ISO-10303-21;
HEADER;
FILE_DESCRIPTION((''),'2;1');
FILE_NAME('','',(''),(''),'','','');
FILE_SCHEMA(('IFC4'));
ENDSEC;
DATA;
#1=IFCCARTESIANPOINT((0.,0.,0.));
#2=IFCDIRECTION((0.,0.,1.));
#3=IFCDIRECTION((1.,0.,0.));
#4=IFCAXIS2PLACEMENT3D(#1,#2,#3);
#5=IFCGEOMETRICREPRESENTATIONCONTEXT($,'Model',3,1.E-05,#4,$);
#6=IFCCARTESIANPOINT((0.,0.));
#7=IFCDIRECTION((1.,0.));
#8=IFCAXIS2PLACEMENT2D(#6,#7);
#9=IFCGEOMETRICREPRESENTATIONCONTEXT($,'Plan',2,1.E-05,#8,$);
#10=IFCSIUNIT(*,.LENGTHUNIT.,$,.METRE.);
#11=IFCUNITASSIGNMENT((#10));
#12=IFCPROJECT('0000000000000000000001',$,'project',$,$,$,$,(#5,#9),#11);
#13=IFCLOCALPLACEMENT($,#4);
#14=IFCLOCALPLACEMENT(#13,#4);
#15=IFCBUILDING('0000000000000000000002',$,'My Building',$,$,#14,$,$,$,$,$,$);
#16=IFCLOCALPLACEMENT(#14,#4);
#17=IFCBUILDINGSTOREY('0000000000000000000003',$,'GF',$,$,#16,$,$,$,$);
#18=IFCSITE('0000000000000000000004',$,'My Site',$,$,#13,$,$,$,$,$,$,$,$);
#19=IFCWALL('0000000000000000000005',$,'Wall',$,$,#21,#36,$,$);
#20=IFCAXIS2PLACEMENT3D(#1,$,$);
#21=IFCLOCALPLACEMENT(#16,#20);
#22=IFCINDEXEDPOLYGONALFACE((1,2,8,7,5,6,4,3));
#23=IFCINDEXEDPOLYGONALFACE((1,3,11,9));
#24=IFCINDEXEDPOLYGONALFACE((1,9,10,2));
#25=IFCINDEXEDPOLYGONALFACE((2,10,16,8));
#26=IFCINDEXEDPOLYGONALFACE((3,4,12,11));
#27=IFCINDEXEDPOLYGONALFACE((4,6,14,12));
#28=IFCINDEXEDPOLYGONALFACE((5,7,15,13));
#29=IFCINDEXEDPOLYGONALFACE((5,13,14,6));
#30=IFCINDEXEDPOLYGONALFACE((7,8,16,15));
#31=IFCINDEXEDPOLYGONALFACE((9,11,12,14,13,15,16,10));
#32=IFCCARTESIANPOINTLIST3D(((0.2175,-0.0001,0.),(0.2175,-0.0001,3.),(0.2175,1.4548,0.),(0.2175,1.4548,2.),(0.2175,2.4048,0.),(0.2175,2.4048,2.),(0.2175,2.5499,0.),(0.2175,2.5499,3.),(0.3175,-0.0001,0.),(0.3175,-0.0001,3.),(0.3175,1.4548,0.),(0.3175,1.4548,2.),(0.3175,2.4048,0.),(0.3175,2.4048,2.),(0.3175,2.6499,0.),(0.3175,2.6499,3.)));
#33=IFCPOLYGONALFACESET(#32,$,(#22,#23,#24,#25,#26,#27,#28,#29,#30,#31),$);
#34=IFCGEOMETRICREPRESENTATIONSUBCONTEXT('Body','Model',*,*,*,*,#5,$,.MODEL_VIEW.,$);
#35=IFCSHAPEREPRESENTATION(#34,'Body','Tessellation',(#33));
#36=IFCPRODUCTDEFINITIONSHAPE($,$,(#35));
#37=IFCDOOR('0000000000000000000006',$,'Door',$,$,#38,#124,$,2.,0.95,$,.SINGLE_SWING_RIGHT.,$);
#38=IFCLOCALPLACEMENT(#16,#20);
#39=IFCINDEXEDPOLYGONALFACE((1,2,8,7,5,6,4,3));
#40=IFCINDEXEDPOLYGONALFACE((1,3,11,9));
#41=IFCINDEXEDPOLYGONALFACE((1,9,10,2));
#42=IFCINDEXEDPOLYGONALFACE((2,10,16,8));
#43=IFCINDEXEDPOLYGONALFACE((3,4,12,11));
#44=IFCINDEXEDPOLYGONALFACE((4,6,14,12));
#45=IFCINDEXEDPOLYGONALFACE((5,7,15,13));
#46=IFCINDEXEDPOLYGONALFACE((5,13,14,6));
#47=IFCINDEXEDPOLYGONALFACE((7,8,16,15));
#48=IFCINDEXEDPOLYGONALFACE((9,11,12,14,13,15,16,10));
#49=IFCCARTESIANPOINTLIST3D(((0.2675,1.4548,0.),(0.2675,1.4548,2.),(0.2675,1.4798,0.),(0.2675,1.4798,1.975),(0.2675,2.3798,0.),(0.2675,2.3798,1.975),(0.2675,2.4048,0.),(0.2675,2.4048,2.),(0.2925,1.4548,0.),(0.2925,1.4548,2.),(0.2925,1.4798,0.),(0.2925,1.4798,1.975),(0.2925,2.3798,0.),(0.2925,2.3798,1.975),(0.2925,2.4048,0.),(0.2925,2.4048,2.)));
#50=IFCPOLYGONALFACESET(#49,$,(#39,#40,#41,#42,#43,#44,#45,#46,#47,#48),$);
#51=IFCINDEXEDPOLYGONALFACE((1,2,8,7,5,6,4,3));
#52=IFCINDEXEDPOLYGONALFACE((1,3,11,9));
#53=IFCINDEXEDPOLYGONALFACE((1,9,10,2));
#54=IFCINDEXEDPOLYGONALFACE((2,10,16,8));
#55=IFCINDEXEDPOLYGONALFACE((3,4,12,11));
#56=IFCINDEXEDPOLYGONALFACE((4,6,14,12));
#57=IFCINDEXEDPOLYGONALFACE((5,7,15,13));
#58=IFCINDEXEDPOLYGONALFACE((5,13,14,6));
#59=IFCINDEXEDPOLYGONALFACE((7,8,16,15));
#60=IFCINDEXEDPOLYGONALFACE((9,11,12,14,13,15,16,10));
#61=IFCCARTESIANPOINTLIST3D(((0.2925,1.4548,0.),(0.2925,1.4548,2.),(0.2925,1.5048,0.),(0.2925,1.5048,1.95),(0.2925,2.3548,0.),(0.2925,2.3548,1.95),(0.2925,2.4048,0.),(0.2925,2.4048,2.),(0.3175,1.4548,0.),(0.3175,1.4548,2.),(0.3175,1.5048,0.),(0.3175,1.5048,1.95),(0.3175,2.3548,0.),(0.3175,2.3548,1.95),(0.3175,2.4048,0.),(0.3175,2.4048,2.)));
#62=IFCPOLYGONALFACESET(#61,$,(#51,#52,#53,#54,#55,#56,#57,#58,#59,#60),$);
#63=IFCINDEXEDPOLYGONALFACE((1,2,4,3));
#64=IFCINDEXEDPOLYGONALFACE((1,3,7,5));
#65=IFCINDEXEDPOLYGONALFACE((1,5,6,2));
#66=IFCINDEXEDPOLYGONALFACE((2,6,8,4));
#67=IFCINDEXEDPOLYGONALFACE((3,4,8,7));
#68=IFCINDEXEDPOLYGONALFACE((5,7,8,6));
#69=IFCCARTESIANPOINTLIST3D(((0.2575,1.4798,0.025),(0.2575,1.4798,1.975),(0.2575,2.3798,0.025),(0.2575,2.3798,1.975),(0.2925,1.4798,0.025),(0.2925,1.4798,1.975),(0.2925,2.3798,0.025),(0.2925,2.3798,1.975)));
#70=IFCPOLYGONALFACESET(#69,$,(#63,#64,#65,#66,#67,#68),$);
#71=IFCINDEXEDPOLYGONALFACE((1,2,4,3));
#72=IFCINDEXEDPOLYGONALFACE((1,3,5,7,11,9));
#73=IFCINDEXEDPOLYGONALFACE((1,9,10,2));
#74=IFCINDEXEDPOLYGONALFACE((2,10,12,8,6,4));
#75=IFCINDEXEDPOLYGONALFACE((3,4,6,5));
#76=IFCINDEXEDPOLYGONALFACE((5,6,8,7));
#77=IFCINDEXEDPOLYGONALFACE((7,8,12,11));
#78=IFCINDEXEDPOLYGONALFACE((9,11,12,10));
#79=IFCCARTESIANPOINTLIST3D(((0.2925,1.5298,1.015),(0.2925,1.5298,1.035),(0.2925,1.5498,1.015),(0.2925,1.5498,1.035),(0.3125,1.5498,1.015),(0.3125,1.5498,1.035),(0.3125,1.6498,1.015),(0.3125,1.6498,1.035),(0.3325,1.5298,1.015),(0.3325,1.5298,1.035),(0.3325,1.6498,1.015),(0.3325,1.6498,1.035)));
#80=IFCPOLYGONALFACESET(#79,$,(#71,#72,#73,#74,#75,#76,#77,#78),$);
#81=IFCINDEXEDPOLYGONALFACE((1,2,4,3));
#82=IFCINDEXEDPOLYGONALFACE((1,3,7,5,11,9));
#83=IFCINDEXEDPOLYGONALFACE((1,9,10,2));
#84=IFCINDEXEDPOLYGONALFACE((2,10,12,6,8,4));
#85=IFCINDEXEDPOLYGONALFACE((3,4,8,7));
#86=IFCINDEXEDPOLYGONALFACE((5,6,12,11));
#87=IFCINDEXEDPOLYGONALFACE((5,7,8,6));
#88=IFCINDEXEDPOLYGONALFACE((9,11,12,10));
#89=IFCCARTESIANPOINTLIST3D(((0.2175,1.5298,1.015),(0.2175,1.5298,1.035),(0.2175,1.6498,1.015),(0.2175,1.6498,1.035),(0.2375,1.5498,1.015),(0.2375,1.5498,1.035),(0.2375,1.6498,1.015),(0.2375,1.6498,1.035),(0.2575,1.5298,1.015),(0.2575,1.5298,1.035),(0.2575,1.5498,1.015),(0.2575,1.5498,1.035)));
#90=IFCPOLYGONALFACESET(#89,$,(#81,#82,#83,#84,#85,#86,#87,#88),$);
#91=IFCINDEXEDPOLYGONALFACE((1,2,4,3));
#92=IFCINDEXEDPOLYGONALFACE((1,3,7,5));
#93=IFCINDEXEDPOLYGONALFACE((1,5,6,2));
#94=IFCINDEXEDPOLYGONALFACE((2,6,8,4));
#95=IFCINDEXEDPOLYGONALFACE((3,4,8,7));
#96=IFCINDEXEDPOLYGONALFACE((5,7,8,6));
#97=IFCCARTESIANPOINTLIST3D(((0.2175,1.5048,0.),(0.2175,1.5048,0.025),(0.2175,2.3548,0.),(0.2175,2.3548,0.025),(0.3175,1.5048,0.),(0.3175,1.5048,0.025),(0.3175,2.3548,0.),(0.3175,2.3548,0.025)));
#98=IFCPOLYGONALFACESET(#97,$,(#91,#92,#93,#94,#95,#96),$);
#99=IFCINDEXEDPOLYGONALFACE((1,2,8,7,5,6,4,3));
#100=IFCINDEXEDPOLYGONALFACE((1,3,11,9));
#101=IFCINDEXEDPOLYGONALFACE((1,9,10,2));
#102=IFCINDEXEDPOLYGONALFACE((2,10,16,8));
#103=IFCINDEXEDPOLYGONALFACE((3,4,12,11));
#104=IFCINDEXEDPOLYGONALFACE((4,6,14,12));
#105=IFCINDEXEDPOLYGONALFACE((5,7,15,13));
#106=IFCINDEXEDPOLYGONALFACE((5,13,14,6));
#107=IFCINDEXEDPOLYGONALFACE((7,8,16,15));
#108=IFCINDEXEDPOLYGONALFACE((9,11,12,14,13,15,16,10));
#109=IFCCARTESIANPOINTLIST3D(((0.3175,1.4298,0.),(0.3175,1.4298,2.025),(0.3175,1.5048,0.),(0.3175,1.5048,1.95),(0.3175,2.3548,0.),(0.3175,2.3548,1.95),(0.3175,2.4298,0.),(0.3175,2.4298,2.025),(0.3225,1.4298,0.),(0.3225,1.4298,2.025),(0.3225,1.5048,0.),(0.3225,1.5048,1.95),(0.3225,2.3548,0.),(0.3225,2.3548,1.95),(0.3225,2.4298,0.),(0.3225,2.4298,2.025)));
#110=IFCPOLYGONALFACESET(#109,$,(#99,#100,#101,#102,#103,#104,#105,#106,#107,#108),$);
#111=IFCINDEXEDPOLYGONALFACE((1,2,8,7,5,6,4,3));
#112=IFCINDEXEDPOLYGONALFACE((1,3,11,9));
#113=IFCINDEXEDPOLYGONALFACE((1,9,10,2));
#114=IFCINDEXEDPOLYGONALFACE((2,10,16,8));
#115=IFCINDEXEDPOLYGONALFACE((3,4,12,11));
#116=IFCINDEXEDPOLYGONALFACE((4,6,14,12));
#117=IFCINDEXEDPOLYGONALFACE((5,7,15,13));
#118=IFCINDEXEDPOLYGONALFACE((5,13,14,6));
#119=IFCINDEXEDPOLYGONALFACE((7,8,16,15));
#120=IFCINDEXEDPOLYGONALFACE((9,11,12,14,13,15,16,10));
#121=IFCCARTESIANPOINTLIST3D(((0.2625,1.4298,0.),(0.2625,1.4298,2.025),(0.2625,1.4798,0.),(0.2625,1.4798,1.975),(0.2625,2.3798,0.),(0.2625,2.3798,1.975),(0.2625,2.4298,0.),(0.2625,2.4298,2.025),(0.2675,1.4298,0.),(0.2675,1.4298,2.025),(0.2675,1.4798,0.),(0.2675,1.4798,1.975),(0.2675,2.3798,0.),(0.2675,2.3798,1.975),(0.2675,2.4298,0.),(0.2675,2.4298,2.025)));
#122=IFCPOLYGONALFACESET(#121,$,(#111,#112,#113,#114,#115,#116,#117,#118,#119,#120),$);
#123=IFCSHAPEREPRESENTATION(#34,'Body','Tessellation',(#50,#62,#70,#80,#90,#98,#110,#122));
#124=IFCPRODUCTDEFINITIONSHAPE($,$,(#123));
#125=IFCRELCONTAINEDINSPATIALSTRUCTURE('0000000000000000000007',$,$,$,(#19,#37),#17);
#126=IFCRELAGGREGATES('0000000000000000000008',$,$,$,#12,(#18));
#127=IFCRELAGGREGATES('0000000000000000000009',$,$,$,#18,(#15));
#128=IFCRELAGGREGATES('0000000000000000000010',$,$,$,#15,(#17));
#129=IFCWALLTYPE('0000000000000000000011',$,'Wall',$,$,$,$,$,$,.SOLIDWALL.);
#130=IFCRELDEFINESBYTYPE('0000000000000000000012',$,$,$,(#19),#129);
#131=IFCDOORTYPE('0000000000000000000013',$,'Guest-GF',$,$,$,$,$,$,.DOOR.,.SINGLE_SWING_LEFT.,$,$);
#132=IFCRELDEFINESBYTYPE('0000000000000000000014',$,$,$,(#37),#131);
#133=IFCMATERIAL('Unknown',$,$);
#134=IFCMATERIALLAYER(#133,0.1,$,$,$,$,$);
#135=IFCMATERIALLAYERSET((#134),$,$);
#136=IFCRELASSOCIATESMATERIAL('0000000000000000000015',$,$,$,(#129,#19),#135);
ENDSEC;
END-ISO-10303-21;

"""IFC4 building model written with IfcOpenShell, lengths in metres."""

from ifc_helpers import new_model, entity, si_unit, frame, origin_with_axes, origin_2d_with_axis, place, context, subcontext, project, spatial, line, indexed_curve, outline, extrude, shape, source, transform, mapped, material, layer, layer_set, layer_usage, type_object, type_shapes, element, fill, save


model = new_model("IFC4")

# Units and contexts
model_context = context("Model", 3, precision=1e-05, world=origin_with_axes())
plan_context = context("Plan", 2, precision=1e-05, world=origin_2d_with_axis())
body_context_1 = subcontext(model_context, "Body", "Model", "MODEL_VIEW")
body_context_2 = subcontext(plan_context, "Body", "Plan", "PLAN_VIEW")
ifc_project = project(units=[si_unit("LENGTHUNIT", "METRE")], contexts=[model_context, plan_context])

# Site, building, storey
site_placement = place(None, origin_with_axes())
site = spatial("IfcSite", under=ifc_project, at=site_placement, Name="My Site")
building_placement = place(site_placement, origin_with_axes())
building = spatial("IfcBuilding", under=site, at=building_placement, Name="My Building")
storey_placement = place(building_placement, origin_with_axes())
storey = spatial("IfcBuildingStorey", under=building, at=storey_placement, Name="GF")

# Shared definitions
ifc_material = material(Name="Unknown")

# Shared definitions
ifc_layer_1 = layer(ifc_material, 0.1)
ifc_layer_set_1 = layer_set([ifc_layer_1])
wall_type = type_object("IfcWallType", Name="Wall", PredefinedType="SOLIDWALL", material=ifc_layer_set_1)

# Wall, opening, door
ifc_layer_usage_1 = layer_usage(ifc_layer_set_1, "AXIS2", "POSITIVE", 0.0)
wall_1_placement = place(storey_placement, frame((0.3175, -0.0001, 0.0), z_axis=(0.0, 0.0, 1.0), x_axis=(0.0, 1.0, 0.0)))
wall_1 = element("IfcWall", 1, at=wall_1_placement, inside=storey, type_object=wall_type, material=ifc_layer_usage_1, Name="Wall", context=body_context_1, shape_type="SweptSolid", body=[
    extrude(outline(indexed_curve([(0.0, 0.0), (0.0, 0.1), (2.55, 0.1), (2.65, 0.0)], segments=[line(1, 2, 3, 4, 1)])), origin_with_axes(), (0.0, 0.0, 1.0), 3.0),
])
shared_shape_1 = source(origin_with_axes(), body_context_1, "Body", "SweptSolid", [
    extrude(outline(indexed_curve([(0.0, 0.0), (0.95, 0.0), (0.95, 2.0), (0.0, 2.0)], segments=[line(1, 2, 3, 4, 1)])), frame((0.0, -0.6, 0.0), z_axis=(0.0, -1.0, 0.0), x_axis=(1.0, 0.0, 0.0)), (0.0, 0.0, -1.0), 1.2),
])
opening_1_placement = place(wall_1_placement, frame((1.4549, 0.0, 0.0), z_axis=(0.0, 0.0, 1.0), x_axis=(1.0, 0.0, 0.0)))
opening_1 = element("IfcOpeningElement", 2, at=opening_1_placement, cuts=wall_1, PredefinedType="OPENING", context=body_context_1, shape_type="MappedRepresentation", body=[
    mapped(shared_shape_1, transform((0.0, 0.0, 0.0), x_axis=(1.0, 0.0, 0.0), y_axis=(0.0, 1.0, 0.0), z_axis=(0.0, 0.0, 1.0), scale=1.0)),
])
door_type_1 = type_object("IfcDoorType", Name="Guest-GF", OperationType="SINGLE_SWING_LEFT", PredefinedType="DOOR")
shared_shape_2 = source(origin_with_axes(), body_context_1, "Body", "SweptSolid", [
    extrude(outline(indexed_curve([(0.0, 0.0), (0.0, 2.0), (0.95, 2.0), (0.95, 0.0), (0.925, 0.0), (0.925, 1.975), (0.025, 1.975), (0.025, 0.0)], segments=[line(1, 2, 3, 4, 5, 6, 7, 8, 1)])), frame((0.0, 0.025, 0.0), z_axis=(0.0, -1.0, 0.0), x_axis=(1.0, 0.0, 0.0)), (0.0, 0.0, -1.0), 0.025),
    extrude(outline(indexed_curve([(0.0, 0.0), (0.0, 2.0), (0.95, 2.0), (0.95, 0.0), (0.9, 0.0), (0.9, 1.95), (0.05, 1.95), (0.05, 0.0)], segments=[line(1, 2, 3, 4, 5, 6, 7, 8, 1)])), frame((0.0, 0.0, 0.0), z_axis=(0.0, -1.0, 0.0), x_axis=(1.0, 0.0, 0.0)), (0.0, 0.0, -1.0), 0.025),
    extrude(outline(indexed_curve([(0.0, 0.0), (0.9, 0.0), (0.9, 0.035), (0.0, 0.035)], segments=[line(1, 2, 3, 4, 1)])), frame((0.025, 0.025, 0.025), z_axis=(0.0, 0.0, 1.0), x_axis=(1.0, 0.0, 0.0)), (0.0, 0.0, 1.0), 1.95),
    extrude(outline(indexed_curve([(0.0, 0.0), (0.0, -0.04), (0.12, -0.04), (0.12, -0.02), (0.02, -0.02), (0.02, 0.0)], segments=[line(1, 2, 3, 4, 5, 6, 1)])), frame((0.075, 0.025, 1.015), z_axis=(0.0, 0.0, 1.0), x_axis=(1.0, 0.0, 0.0)), (0.0, 0.0, 1.0), 0.02),
    extrude(outline(indexed_curve([(0.0, 0.0), (0.0, 0.04), (0.12, 0.04), (0.12, 0.02), (0.02, 0.02), (0.02, 0.0)], segments=[line(1, 2, 3, 4, 5, 6, 1)])), frame((0.075, 0.06, 1.015), z_axis=(0.0, 0.0, 1.0), x_axis=(1.0, 0.0, 0.0)), (0.0, 0.0, 1.0), 0.02),
    extrude(outline(indexed_curve([(0.0, 0.0), (0.85, 0.0), (0.85, 0.1), (0.0, 0.1)], segments=[line(1, 2, 3, 4, 1)])), frame((0.05, 0.0, 0.0), z_axis=(0.0, 0.0, 1.0), x_axis=(1.0, 0.0, 0.0)), (0.0, 0.0, 1.0), 0.025),
    extrude(outline(indexed_curve([(0.0, 0.0), (0.0, 2.025), (1.0, 2.025), (1.0, 0.0), (0.925, 0.0), (0.925, 1.95), (0.075, 1.95), (0.075, 0.0)], segments=[line(1, 2, 3, 4, 5, 6, 7, 8, 1)])), frame((-0.025, -0.005, 0.0), z_axis=(0.0, -1.0, 0.0), x_axis=(1.0, 0.0, 0.0)), (0.0, 0.0, -1.0), 0.005),
    extrude(outline(indexed_curve([(0.0, 0.0), (0.0, 2.025), (1.0, 2.025), (1.0, 0.0), (0.95, 0.0), (0.95, 1.975), (0.05, 1.975), (0.05, 0.0)], segments=[line(1, 2, 3, 4, 5, 6, 7, 8, 1)])), frame((-0.025, 0.05, 0.0), z_axis=(0.0, -1.0, 0.0), x_axis=(1.0, 0.0, 0.0)), (0.0, 0.0, -1.0), 0.005),
])
shared_shape_3 = source(origin_with_axes(), body_context_2, "Body", "Curve2D", [
    entity("IfcIndexedPolyCurve", entity("IfcCartesianPointList2D", [[0.0, 0.0], [0.0, 0.05], [0.025, 0.05], [0.025, 0.025], [0.05, 0.025], [0.05, 0.0]]), [entity("IfcLineIndex", [1, 2, 3, 4, 5, 6, 1])]),
    entity("IfcIndexedPolyCurve", entity("IfcCartesianPointList2D", [[0.95, 0.0], [0.95, 0.05], [0.925, 0.05], [0.925, 0.025], [0.9, 0.025], [0.9, 0.0]]), [entity("IfcLineIndex", [1, 2, 3, 4, 5, 6, 1])]),
    entity("IfcTrimmedCurve", entity("IfcEllipse", entity("IfcAxis2Placement2D", entity("IfcCartesianPoint", [0.89, 0.05]), entity("IfcDirection", [1.0, 0.0])), 0.865, 0.9), [entity("IfcCartesianPoint", [0.89, 0.95])], [entity("IfcCartesianPoint", [0.025, 0.05])], True, "CARTESIAN"),
    entity("IfcIndexedPolyCurve", entity("IfcCartesianPointList2D", [[0.925, 0.05], [0.89, 0.05], [0.89, 0.95], [0.925, 0.95]]), [entity("IfcLineIndex", [1, 2, 3, 4, 1])]),
])
type_shapes(door_type_1, [shared_shape_2, shared_shape_3])
door_1_placement = place(opening_1_placement, frame((0.0, 0.0, 0.0), z_axis=(0.0, 0.0, 1.0), x_axis=(1.0, 0.0, 0.0)))
door_1 = element("IfcDoor", 3, at=door_1_placement, inside=storey, type_object=door_type_1, Name="Door", OperationType="SINGLE_SWING_RIGHT", OverallHeight=2.0, OverallWidth=0.95, shapes=[
    shape(body_context_1, "Body", "MappedRepresentation", [mapped(shared_shape_2, transform((0.0, 0.0, 0.0), x_axis=(1.0, 0.0, 0.0), y_axis=(0.0, 1.0, 0.0), z_axis=(0.0, 0.0, 1.0), scale=1.0))]),
    shape(body_context_2, "Body", "MappedRepresentation", [mapped(shared_shape_3, transform((0.0, 0.0, 0.0), x_axis=(1.0, 0.0, 0.0), y_axis=(0.0, 1.0, 0.0), z_axis=(0.0, 0.0, 1.0), scale=1.0))]),
])
fill(opening_1, door_1)

save(model, "model.ifc")
